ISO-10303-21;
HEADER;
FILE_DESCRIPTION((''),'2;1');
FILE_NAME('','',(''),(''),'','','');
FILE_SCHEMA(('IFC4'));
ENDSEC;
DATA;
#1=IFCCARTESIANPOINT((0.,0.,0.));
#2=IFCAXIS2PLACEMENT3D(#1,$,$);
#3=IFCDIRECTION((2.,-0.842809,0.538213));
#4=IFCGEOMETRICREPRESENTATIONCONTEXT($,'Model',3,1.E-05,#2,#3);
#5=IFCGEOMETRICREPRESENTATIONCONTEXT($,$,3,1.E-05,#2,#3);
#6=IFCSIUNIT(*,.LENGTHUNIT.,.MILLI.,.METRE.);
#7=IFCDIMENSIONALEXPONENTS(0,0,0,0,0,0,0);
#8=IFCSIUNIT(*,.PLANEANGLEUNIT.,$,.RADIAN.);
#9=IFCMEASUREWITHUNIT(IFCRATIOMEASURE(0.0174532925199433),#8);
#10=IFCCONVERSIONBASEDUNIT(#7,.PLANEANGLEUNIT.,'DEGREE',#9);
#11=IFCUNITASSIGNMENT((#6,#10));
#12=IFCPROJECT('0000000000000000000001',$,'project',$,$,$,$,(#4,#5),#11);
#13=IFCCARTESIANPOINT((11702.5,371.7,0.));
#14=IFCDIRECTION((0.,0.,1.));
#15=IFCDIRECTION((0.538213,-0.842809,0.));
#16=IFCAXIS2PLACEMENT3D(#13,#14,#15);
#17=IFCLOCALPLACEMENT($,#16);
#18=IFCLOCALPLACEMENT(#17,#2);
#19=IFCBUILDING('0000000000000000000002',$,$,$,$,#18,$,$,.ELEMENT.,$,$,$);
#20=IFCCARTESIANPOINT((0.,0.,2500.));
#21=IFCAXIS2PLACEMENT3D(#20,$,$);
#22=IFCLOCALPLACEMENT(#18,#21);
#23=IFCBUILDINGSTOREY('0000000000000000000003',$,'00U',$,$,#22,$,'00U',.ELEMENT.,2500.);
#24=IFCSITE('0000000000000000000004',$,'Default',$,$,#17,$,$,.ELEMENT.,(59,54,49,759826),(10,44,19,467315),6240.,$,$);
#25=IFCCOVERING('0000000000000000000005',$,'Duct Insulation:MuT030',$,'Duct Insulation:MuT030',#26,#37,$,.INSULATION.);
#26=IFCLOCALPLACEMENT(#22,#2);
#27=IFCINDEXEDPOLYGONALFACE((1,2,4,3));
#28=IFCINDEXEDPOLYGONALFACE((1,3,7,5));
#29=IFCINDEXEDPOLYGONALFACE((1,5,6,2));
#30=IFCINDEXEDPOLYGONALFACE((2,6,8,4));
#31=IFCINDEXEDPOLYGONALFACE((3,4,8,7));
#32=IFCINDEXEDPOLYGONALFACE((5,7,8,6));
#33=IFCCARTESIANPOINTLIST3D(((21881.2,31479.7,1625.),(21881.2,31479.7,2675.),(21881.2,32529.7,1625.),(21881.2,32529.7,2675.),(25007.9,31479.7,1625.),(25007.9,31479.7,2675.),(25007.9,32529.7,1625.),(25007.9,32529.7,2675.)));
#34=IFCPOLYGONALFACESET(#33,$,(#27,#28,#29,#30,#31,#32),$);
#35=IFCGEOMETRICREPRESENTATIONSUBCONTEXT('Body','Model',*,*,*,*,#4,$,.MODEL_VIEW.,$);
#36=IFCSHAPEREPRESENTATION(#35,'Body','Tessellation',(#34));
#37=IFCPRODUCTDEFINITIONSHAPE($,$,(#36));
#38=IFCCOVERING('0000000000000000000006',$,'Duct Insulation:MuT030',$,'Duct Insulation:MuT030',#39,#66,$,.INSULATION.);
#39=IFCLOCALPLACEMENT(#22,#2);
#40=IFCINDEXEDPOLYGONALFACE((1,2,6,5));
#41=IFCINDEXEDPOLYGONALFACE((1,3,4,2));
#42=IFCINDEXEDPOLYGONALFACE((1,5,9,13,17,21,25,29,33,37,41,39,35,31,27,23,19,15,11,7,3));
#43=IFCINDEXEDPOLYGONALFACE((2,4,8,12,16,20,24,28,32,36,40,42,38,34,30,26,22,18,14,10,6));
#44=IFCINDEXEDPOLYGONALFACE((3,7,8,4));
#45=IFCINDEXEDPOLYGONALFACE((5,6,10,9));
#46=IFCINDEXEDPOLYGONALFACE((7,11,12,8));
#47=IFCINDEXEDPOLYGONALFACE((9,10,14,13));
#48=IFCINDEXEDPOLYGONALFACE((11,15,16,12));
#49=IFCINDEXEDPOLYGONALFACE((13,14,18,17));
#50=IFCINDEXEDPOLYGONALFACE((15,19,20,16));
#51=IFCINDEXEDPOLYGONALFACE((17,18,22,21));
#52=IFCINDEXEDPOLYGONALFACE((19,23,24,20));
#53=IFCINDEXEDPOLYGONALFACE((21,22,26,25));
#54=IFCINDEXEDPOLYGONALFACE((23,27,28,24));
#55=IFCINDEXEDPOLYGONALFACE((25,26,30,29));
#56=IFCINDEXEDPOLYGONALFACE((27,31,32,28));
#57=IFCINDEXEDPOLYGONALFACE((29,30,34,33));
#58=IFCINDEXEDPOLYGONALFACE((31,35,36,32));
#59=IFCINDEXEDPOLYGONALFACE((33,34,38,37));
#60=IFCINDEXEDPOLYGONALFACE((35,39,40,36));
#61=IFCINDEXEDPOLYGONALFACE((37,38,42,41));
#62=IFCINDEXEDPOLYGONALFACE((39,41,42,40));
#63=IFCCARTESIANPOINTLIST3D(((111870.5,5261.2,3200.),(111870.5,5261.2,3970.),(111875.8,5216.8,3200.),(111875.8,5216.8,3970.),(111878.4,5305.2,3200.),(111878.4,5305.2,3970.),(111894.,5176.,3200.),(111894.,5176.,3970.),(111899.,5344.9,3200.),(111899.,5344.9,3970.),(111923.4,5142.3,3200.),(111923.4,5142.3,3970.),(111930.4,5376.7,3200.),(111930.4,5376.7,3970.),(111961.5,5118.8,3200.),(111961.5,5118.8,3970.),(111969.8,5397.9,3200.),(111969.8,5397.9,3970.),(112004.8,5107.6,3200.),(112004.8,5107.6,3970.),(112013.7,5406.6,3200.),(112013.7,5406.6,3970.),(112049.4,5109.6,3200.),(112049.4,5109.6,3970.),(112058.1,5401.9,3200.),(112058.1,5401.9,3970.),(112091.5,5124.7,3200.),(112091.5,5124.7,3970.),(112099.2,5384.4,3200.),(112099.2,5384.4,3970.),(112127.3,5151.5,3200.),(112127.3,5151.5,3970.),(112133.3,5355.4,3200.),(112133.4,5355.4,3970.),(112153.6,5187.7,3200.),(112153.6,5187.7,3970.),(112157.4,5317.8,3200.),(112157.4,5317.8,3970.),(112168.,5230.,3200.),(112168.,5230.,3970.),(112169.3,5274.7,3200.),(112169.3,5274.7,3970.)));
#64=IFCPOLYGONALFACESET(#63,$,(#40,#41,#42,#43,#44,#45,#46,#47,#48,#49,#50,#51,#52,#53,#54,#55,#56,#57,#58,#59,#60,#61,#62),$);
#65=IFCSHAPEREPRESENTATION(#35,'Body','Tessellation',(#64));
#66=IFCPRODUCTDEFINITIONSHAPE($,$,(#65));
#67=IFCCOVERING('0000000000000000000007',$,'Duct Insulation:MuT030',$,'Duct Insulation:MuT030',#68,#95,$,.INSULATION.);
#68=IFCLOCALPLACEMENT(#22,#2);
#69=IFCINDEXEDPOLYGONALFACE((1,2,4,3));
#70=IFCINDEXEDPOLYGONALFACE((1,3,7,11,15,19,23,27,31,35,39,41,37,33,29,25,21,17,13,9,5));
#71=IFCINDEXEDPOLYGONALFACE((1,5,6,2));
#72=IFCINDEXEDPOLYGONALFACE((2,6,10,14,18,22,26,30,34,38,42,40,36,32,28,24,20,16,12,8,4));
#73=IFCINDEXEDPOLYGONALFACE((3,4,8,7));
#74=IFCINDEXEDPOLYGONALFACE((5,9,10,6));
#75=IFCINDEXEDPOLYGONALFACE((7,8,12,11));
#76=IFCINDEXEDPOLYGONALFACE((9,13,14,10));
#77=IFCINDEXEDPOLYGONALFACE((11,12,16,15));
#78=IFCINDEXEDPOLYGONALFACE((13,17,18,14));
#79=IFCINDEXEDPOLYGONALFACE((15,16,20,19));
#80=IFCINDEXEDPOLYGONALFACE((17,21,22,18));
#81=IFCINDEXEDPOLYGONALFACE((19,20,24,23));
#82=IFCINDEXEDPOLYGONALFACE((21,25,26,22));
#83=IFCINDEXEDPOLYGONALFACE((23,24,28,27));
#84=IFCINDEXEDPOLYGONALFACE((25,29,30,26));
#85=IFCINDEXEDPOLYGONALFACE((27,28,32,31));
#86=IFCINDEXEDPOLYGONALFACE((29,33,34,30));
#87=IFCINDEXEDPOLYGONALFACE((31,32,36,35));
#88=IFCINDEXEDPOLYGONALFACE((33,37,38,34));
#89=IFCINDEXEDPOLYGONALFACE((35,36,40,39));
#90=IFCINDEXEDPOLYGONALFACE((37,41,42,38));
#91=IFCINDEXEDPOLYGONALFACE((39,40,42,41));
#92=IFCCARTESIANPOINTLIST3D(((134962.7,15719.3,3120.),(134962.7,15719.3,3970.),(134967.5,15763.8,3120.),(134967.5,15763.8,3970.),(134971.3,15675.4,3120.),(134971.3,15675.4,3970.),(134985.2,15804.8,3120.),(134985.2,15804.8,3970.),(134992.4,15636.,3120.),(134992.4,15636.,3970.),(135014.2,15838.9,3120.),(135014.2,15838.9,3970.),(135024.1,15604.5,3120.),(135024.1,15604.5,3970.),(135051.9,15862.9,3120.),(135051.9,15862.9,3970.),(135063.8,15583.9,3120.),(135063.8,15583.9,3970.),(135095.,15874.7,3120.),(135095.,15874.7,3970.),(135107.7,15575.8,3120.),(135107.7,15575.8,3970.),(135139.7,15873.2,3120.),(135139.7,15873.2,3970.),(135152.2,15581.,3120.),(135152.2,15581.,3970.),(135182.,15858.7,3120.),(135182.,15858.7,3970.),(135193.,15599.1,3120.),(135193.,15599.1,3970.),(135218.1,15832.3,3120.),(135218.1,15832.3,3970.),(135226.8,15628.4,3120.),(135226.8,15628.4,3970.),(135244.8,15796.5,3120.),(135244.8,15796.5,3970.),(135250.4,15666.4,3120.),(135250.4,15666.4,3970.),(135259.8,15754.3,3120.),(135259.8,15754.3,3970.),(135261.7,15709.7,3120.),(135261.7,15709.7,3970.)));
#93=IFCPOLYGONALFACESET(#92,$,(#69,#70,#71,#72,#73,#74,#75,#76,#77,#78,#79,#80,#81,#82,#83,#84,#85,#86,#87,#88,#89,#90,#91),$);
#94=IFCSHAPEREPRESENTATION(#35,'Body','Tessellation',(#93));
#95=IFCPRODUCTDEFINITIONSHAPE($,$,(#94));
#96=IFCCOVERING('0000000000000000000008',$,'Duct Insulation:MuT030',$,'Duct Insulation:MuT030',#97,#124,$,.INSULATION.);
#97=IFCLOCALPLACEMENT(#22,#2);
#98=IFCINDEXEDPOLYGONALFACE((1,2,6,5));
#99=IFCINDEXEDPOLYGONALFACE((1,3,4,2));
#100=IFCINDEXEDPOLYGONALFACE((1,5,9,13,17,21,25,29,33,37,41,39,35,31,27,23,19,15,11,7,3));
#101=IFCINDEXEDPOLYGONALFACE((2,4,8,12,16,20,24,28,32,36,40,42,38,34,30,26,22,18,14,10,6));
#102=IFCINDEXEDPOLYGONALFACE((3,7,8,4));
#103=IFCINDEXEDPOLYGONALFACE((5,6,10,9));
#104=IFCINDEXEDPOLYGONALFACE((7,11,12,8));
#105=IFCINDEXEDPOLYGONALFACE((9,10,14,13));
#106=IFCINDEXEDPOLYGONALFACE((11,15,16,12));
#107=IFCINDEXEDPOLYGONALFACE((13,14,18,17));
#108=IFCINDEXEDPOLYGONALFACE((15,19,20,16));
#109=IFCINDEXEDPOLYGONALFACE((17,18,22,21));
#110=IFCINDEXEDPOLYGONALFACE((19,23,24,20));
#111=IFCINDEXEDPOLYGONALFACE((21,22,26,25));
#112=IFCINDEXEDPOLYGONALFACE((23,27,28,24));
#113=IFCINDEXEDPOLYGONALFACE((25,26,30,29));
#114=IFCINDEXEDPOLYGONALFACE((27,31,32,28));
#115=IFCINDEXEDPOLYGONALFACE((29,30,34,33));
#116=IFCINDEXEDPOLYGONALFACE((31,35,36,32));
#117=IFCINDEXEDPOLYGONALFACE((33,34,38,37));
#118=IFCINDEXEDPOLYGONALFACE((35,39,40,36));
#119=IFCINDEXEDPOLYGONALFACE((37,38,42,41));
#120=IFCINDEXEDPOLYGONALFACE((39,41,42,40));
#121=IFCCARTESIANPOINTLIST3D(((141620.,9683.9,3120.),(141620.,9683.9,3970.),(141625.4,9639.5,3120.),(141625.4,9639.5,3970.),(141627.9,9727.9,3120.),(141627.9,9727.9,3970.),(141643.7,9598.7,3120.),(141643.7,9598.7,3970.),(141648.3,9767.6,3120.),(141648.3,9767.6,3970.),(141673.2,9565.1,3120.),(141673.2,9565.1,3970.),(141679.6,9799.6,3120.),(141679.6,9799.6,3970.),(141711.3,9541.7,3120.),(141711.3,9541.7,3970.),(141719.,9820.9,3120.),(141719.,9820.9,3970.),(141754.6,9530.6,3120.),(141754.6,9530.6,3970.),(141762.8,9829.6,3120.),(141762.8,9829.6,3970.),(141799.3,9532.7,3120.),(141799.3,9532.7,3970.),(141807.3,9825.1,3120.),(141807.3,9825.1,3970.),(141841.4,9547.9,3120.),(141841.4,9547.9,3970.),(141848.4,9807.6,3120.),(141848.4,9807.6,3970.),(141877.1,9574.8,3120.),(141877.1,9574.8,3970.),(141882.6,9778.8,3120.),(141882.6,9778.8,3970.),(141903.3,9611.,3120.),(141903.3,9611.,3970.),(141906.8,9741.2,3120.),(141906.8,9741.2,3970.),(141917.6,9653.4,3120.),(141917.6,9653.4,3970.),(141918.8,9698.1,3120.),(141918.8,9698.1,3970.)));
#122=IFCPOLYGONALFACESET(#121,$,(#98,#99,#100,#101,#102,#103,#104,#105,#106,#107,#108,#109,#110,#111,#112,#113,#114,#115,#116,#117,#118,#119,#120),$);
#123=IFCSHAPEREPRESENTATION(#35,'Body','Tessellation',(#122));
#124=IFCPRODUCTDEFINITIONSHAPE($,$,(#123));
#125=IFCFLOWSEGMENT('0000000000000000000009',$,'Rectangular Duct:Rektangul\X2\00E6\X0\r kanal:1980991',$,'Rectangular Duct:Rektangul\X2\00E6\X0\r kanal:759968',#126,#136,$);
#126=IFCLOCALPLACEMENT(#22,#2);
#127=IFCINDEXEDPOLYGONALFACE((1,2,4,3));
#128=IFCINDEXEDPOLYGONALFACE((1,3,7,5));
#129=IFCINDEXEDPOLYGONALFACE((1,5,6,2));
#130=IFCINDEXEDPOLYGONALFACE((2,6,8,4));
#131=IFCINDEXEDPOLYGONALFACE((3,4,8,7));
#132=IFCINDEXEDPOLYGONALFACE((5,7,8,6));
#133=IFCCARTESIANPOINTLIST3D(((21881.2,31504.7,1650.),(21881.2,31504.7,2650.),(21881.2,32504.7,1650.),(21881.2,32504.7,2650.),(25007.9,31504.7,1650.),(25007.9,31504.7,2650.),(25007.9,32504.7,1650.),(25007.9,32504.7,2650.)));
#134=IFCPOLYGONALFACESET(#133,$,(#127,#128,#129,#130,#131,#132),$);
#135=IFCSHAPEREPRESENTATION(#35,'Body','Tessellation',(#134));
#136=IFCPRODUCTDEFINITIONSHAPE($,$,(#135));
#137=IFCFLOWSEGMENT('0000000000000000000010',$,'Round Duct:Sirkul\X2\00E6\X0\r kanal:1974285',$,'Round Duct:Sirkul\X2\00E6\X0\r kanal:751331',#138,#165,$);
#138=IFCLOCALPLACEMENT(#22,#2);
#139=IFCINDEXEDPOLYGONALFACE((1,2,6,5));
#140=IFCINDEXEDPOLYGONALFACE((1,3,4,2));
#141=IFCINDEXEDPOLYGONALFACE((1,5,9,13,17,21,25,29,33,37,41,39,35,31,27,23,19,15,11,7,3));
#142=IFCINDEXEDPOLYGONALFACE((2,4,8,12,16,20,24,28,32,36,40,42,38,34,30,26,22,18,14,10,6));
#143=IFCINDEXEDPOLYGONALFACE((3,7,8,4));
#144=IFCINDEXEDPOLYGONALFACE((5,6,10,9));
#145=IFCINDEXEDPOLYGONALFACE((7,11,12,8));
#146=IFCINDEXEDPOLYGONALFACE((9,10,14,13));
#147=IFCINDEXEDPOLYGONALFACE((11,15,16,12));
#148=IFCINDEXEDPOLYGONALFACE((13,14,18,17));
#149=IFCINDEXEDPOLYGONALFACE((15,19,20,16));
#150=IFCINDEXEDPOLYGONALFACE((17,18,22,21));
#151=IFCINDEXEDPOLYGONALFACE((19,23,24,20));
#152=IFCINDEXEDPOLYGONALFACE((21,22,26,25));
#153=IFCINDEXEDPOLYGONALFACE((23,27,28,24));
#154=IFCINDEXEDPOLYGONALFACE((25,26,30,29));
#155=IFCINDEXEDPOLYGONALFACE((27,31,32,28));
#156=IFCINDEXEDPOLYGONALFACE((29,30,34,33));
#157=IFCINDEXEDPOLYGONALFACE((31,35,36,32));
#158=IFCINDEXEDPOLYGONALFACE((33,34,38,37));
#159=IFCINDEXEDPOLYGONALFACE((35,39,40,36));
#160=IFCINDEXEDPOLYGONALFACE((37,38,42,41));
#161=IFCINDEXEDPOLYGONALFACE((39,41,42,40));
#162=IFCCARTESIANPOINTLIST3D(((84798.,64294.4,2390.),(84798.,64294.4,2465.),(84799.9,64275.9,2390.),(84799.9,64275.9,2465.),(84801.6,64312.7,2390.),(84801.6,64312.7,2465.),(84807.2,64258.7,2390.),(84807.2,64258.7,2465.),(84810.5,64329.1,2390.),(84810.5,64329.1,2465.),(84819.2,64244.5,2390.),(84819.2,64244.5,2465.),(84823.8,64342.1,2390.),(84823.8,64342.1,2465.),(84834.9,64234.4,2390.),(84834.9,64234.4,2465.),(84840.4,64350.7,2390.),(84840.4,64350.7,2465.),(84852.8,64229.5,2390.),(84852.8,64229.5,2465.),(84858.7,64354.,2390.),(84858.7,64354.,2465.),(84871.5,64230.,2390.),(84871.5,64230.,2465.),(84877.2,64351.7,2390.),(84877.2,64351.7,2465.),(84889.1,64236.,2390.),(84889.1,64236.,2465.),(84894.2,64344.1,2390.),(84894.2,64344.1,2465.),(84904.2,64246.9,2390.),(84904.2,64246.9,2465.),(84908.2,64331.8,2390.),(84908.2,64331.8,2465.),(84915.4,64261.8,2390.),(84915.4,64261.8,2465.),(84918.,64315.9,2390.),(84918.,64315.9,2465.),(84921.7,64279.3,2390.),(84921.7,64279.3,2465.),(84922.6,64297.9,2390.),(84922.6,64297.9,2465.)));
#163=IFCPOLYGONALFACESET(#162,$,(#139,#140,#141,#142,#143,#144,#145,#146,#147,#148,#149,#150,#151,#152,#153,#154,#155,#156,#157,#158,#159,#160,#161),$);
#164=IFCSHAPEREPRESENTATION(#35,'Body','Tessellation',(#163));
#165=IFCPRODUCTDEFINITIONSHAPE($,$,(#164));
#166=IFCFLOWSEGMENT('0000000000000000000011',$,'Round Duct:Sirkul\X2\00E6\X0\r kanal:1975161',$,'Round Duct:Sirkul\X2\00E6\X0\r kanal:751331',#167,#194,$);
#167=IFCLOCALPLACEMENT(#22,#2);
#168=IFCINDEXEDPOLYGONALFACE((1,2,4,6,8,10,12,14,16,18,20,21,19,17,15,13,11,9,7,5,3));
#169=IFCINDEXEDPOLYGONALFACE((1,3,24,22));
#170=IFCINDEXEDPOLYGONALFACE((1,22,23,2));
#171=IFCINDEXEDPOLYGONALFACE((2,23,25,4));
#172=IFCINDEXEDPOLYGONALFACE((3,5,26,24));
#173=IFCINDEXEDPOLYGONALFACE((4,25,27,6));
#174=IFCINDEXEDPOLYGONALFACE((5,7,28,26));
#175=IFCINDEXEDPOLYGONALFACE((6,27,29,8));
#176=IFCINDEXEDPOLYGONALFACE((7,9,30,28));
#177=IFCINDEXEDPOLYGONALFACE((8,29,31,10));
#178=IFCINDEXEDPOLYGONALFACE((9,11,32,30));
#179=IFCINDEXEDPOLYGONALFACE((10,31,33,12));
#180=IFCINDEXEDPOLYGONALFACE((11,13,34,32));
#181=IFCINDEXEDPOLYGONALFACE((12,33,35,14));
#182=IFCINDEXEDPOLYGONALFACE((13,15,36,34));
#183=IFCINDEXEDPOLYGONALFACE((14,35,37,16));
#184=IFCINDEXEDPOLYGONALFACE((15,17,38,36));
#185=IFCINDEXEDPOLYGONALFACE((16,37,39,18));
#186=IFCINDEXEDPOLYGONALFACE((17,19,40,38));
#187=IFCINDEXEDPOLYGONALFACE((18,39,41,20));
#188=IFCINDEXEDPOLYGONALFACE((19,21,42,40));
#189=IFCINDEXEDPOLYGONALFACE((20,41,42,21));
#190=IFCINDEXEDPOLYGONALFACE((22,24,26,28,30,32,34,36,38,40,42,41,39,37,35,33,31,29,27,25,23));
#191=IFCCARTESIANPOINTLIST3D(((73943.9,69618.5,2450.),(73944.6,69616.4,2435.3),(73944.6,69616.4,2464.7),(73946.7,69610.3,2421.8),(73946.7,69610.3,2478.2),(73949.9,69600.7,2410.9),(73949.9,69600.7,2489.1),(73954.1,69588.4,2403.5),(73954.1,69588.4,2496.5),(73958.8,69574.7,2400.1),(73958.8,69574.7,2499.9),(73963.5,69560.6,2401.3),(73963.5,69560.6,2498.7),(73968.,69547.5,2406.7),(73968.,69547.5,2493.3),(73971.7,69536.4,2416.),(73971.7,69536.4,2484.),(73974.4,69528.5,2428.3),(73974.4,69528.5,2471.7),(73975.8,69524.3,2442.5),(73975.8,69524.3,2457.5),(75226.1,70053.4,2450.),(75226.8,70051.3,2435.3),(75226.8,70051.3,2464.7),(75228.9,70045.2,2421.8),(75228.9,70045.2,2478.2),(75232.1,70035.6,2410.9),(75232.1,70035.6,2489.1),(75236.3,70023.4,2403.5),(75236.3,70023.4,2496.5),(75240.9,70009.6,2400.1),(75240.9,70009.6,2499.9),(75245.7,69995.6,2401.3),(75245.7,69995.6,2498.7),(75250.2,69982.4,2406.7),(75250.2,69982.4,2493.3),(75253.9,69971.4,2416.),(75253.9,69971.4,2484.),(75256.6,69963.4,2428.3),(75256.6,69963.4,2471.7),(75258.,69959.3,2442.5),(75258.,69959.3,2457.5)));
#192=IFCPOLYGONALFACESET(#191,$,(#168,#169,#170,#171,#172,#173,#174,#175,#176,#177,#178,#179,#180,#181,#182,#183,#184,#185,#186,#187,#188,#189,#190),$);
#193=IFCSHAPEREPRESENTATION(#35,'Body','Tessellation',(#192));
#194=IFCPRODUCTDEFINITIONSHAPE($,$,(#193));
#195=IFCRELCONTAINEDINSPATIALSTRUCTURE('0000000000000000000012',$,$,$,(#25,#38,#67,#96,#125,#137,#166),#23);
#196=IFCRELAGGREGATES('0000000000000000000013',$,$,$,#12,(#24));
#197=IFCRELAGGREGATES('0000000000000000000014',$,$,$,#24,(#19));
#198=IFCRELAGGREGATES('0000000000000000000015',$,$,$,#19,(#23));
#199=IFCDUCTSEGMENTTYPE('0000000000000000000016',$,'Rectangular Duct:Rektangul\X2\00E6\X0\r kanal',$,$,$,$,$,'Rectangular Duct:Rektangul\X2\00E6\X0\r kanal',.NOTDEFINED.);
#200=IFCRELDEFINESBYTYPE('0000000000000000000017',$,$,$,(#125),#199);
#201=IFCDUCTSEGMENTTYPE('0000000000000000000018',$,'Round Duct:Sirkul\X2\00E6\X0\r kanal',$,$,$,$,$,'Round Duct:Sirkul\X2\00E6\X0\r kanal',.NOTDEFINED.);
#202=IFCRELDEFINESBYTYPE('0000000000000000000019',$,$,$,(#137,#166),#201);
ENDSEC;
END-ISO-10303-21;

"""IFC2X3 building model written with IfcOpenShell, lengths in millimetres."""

from ifc_helpers import new_model, entity, si_unit, converted_unit, direction, frame, frame_2d, origin, origin_2d_with_axis, place, context, subcontext, project, spatial, rectangle, circle, extrude, type_object, element, save


model = new_model("IFC2X3")

# Units and contexts
model_context = context("Model", 3, precision=1e-05, world=origin(), true_north=direction((2.0, -0.842809, 0.538213)))
context_of_model = context(None, 3, precision=1e-05, world=origin(), true_north=direction((2.0, -0.842809, 0.538213)))
body_context = subcontext(model_context, "Body", "Model", "MODEL_VIEW")
ifc_project = project(units=[si_unit("LENGTHUNIT", "METRE", prefix="MILLI"), converted_unit("PLANEANGLEUNIT", "DEGREE", entity("IfcRatioMeasure", 0.0174532925199433), si_unit("PLANEANGLEUNIT", "RADIAN"), dimensions=[0, 0, 0, 0, 0, 0, 0])], contexts=[model_context, context_of_model])

# Site, building, storey
site_placement = place(None, frame((11702.5, 371.7, 0.0), z_axis=(0.0, 0.0, 1.0), x_axis=(0.538213, -0.842809, 0.0)))
site = spatial("IfcSite", under=ifc_project, at=site_placement, Name="Default", CompositionType="ELEMENT", RefLatitude=(59, 54, 49, 759826), RefLongitude=(10, 44, 19, 467315), RefElevation=6240.0)
building_placement = place(site_placement, origin())
building = spatial("IfcBuilding", under=site, at=building_placement, CompositionType="ELEMENT")
storey_placement = place(building_placement, frame((0.0, 0.0, 2500.0)))
storey = spatial("IfcBuildingStorey", under=building, at=storey_placement, Name="00U", LongName="00U", CompositionType="ELEMENT", Elevation=2500.0)

# Coverings
covering_1_placement = place(storey_placement, origin())
element("IfcCovering", 1, at=covering_1_placement, inside=storey, Name="Duct Insulation:MuT030", ObjectType="Duct Insulation:MuT030", PredefinedType="INSULATION", context=body_context, shape_type="SweptSolid", body=[
    extrude(rectangle(XDim=3126.7, YDim=1050.0, at=origin_2d_with_axis()), frame((23444.6, 32004.7, 1625.0), z_axis=(0.0, 0.0, 1.0), x_axis=(-1.0, 0.0, 0.0)), (0.0, 0.0, 1.0), 1050.0),
])
covering_2_placement = place(storey_placement, origin())
element("IfcCovering", 2, at=covering_2_placement, inside=storey, Name="Duct Insulation:MuT030", ObjectType="Duct Insulation:MuT030", PredefinedType="INSULATION", context=body_context, shape_type="SweptSolid", body=[
    extrude(circle(Radius=150.0, at=frame_2d((0.0, 0.0), x_axis=(1.0, 0.0))), frame((112020.4, 5256.7, 3200.0), z_axis=(0.000001, 0.0, 1.0), x_axis=(-0.96392, -0.266194, 0.000001)), (0.0, 0.0, 1.0), 770.0),
])
covering_3_placement = place(storey_placement, origin())
element("IfcCovering", 3, at=covering_3_placement, inside=storey, Name="Duct Insulation:MuT030", ObjectType="Duct Insulation:MuT030", PredefinedType="INSULATION", context=body_context, shape_type="SweptSolid", body=[
    extrude(circle(Radius=150.0, at=origin_2d_with_axis()), frame((135112.6, 15725.7, 3120.0), z_axis=(0.000001, 0.0, 1.0), x_axis=(0.46271, 0.88651, 0.0)), (0.0, 0.0, 1.0), 850.0),
])
covering_4_placement = place(storey_placement, origin())
element("IfcCovering", 4, at=covering_4_placement, inside=storey, Name="Duct Insulation:MuT030", ObjectType="Duct Insulation:MuT030", PredefinedType="INSULATION", context=body_context, shape_type="SweptSolid", body=[
    extrude(circle(Radius=150.0, at=frame_2d((0.0, 0.0), x_axis=(1.0, 0.0))), frame((141769.9, 9679.8, 3120.0), z_axis=(0.000001, 0.0, 1.0), x_axis=(-0.999628, 0.02726, 0.000001)), (0.0, 0.0, 1.0), 850.0),
])

# Flow segments
duct_segment_type_1 = type_object("IfcDuctSegmentType", Name="Rectangular Duct:Rektangulær kanal", ElementType="Rectangular Duct:Rektangulær kanal", PredefinedType="NOTDEFINED")
flow_segment_1_placement = place(storey_placement, origin())
element("IfcFlowSegment", 5, at=flow_segment_1_placement, inside=storey, type_object=duct_segment_type_1, Name="Rectangular Duct:Rektangulær kanal:1980991", ObjectType="Rectangular Duct:Rektangulær kanal:759968", context=body_context, shape_type="SweptSolid", body=[
    extrude(rectangle(XDim=3126.7, YDim=1000.0, at=frame_2d((0.0, 0.0), x_axis=(1.0, 0.0))), frame((23444.6, 32004.7, 1650.0), z_axis=(0.0, 0.0, 1.0), x_axis=(-1.0, 0.0, 0.0)), (0.0, 0.0, 1.0), 1000.0),
])
duct_segment_type_2 = type_object("IfcDuctSegmentType", Name="Round Duct:Sirkulær kanal", ElementType="Round Duct:Sirkulær kanal", PredefinedType="NOTDEFINED")
flow_segment_2_placement = place(storey_placement, origin())
element("IfcFlowSegment", 6, at=flow_segment_2_placement, inside=storey, type_object=duct_segment_type_2, Name="Round Duct:Sirkulær kanal:1974285", ObjectType="Round Duct:Sirkulær kanal:751331", context=body_context, shape_type="SweptSolid", body=[
    extrude(circle(Radius=62.5, at=frame_2d((0.0, 0.0), x_axis=(1.0, 0.0))), frame((84860.4, 64291.5, 2390.0), z_axis=(0.0, 0.0, 1.0), x_axis=(-0.321246, 0.946996, 0.0)), (0.0, 0.0, 1.0), 75.0),
])
flow_segment_3_placement = place(storey_placement, origin())
element("IfcFlowSegment", 7, at=flow_segment_3_placement, inside=storey, type_object=duct_segment_type_2, Name="Round Duct:Sirkulær kanal:1975161", ObjectType="Round Duct:Sirkulær kanal:751331", context=body_context, shape_type="SweptSolid", body=[
    extrude(circle(Radius=50.0, at=origin_2d_with_axis()), frame((73960.0, 69571.1, 2450.0), z_axis=(0.946994, 0.321251, 0.0), x_axis=(-0.321251, 0.946994, 0.0)), (0.0, 0.0, 1.0), 1353.9),
])

save(model, "model.ifc")
